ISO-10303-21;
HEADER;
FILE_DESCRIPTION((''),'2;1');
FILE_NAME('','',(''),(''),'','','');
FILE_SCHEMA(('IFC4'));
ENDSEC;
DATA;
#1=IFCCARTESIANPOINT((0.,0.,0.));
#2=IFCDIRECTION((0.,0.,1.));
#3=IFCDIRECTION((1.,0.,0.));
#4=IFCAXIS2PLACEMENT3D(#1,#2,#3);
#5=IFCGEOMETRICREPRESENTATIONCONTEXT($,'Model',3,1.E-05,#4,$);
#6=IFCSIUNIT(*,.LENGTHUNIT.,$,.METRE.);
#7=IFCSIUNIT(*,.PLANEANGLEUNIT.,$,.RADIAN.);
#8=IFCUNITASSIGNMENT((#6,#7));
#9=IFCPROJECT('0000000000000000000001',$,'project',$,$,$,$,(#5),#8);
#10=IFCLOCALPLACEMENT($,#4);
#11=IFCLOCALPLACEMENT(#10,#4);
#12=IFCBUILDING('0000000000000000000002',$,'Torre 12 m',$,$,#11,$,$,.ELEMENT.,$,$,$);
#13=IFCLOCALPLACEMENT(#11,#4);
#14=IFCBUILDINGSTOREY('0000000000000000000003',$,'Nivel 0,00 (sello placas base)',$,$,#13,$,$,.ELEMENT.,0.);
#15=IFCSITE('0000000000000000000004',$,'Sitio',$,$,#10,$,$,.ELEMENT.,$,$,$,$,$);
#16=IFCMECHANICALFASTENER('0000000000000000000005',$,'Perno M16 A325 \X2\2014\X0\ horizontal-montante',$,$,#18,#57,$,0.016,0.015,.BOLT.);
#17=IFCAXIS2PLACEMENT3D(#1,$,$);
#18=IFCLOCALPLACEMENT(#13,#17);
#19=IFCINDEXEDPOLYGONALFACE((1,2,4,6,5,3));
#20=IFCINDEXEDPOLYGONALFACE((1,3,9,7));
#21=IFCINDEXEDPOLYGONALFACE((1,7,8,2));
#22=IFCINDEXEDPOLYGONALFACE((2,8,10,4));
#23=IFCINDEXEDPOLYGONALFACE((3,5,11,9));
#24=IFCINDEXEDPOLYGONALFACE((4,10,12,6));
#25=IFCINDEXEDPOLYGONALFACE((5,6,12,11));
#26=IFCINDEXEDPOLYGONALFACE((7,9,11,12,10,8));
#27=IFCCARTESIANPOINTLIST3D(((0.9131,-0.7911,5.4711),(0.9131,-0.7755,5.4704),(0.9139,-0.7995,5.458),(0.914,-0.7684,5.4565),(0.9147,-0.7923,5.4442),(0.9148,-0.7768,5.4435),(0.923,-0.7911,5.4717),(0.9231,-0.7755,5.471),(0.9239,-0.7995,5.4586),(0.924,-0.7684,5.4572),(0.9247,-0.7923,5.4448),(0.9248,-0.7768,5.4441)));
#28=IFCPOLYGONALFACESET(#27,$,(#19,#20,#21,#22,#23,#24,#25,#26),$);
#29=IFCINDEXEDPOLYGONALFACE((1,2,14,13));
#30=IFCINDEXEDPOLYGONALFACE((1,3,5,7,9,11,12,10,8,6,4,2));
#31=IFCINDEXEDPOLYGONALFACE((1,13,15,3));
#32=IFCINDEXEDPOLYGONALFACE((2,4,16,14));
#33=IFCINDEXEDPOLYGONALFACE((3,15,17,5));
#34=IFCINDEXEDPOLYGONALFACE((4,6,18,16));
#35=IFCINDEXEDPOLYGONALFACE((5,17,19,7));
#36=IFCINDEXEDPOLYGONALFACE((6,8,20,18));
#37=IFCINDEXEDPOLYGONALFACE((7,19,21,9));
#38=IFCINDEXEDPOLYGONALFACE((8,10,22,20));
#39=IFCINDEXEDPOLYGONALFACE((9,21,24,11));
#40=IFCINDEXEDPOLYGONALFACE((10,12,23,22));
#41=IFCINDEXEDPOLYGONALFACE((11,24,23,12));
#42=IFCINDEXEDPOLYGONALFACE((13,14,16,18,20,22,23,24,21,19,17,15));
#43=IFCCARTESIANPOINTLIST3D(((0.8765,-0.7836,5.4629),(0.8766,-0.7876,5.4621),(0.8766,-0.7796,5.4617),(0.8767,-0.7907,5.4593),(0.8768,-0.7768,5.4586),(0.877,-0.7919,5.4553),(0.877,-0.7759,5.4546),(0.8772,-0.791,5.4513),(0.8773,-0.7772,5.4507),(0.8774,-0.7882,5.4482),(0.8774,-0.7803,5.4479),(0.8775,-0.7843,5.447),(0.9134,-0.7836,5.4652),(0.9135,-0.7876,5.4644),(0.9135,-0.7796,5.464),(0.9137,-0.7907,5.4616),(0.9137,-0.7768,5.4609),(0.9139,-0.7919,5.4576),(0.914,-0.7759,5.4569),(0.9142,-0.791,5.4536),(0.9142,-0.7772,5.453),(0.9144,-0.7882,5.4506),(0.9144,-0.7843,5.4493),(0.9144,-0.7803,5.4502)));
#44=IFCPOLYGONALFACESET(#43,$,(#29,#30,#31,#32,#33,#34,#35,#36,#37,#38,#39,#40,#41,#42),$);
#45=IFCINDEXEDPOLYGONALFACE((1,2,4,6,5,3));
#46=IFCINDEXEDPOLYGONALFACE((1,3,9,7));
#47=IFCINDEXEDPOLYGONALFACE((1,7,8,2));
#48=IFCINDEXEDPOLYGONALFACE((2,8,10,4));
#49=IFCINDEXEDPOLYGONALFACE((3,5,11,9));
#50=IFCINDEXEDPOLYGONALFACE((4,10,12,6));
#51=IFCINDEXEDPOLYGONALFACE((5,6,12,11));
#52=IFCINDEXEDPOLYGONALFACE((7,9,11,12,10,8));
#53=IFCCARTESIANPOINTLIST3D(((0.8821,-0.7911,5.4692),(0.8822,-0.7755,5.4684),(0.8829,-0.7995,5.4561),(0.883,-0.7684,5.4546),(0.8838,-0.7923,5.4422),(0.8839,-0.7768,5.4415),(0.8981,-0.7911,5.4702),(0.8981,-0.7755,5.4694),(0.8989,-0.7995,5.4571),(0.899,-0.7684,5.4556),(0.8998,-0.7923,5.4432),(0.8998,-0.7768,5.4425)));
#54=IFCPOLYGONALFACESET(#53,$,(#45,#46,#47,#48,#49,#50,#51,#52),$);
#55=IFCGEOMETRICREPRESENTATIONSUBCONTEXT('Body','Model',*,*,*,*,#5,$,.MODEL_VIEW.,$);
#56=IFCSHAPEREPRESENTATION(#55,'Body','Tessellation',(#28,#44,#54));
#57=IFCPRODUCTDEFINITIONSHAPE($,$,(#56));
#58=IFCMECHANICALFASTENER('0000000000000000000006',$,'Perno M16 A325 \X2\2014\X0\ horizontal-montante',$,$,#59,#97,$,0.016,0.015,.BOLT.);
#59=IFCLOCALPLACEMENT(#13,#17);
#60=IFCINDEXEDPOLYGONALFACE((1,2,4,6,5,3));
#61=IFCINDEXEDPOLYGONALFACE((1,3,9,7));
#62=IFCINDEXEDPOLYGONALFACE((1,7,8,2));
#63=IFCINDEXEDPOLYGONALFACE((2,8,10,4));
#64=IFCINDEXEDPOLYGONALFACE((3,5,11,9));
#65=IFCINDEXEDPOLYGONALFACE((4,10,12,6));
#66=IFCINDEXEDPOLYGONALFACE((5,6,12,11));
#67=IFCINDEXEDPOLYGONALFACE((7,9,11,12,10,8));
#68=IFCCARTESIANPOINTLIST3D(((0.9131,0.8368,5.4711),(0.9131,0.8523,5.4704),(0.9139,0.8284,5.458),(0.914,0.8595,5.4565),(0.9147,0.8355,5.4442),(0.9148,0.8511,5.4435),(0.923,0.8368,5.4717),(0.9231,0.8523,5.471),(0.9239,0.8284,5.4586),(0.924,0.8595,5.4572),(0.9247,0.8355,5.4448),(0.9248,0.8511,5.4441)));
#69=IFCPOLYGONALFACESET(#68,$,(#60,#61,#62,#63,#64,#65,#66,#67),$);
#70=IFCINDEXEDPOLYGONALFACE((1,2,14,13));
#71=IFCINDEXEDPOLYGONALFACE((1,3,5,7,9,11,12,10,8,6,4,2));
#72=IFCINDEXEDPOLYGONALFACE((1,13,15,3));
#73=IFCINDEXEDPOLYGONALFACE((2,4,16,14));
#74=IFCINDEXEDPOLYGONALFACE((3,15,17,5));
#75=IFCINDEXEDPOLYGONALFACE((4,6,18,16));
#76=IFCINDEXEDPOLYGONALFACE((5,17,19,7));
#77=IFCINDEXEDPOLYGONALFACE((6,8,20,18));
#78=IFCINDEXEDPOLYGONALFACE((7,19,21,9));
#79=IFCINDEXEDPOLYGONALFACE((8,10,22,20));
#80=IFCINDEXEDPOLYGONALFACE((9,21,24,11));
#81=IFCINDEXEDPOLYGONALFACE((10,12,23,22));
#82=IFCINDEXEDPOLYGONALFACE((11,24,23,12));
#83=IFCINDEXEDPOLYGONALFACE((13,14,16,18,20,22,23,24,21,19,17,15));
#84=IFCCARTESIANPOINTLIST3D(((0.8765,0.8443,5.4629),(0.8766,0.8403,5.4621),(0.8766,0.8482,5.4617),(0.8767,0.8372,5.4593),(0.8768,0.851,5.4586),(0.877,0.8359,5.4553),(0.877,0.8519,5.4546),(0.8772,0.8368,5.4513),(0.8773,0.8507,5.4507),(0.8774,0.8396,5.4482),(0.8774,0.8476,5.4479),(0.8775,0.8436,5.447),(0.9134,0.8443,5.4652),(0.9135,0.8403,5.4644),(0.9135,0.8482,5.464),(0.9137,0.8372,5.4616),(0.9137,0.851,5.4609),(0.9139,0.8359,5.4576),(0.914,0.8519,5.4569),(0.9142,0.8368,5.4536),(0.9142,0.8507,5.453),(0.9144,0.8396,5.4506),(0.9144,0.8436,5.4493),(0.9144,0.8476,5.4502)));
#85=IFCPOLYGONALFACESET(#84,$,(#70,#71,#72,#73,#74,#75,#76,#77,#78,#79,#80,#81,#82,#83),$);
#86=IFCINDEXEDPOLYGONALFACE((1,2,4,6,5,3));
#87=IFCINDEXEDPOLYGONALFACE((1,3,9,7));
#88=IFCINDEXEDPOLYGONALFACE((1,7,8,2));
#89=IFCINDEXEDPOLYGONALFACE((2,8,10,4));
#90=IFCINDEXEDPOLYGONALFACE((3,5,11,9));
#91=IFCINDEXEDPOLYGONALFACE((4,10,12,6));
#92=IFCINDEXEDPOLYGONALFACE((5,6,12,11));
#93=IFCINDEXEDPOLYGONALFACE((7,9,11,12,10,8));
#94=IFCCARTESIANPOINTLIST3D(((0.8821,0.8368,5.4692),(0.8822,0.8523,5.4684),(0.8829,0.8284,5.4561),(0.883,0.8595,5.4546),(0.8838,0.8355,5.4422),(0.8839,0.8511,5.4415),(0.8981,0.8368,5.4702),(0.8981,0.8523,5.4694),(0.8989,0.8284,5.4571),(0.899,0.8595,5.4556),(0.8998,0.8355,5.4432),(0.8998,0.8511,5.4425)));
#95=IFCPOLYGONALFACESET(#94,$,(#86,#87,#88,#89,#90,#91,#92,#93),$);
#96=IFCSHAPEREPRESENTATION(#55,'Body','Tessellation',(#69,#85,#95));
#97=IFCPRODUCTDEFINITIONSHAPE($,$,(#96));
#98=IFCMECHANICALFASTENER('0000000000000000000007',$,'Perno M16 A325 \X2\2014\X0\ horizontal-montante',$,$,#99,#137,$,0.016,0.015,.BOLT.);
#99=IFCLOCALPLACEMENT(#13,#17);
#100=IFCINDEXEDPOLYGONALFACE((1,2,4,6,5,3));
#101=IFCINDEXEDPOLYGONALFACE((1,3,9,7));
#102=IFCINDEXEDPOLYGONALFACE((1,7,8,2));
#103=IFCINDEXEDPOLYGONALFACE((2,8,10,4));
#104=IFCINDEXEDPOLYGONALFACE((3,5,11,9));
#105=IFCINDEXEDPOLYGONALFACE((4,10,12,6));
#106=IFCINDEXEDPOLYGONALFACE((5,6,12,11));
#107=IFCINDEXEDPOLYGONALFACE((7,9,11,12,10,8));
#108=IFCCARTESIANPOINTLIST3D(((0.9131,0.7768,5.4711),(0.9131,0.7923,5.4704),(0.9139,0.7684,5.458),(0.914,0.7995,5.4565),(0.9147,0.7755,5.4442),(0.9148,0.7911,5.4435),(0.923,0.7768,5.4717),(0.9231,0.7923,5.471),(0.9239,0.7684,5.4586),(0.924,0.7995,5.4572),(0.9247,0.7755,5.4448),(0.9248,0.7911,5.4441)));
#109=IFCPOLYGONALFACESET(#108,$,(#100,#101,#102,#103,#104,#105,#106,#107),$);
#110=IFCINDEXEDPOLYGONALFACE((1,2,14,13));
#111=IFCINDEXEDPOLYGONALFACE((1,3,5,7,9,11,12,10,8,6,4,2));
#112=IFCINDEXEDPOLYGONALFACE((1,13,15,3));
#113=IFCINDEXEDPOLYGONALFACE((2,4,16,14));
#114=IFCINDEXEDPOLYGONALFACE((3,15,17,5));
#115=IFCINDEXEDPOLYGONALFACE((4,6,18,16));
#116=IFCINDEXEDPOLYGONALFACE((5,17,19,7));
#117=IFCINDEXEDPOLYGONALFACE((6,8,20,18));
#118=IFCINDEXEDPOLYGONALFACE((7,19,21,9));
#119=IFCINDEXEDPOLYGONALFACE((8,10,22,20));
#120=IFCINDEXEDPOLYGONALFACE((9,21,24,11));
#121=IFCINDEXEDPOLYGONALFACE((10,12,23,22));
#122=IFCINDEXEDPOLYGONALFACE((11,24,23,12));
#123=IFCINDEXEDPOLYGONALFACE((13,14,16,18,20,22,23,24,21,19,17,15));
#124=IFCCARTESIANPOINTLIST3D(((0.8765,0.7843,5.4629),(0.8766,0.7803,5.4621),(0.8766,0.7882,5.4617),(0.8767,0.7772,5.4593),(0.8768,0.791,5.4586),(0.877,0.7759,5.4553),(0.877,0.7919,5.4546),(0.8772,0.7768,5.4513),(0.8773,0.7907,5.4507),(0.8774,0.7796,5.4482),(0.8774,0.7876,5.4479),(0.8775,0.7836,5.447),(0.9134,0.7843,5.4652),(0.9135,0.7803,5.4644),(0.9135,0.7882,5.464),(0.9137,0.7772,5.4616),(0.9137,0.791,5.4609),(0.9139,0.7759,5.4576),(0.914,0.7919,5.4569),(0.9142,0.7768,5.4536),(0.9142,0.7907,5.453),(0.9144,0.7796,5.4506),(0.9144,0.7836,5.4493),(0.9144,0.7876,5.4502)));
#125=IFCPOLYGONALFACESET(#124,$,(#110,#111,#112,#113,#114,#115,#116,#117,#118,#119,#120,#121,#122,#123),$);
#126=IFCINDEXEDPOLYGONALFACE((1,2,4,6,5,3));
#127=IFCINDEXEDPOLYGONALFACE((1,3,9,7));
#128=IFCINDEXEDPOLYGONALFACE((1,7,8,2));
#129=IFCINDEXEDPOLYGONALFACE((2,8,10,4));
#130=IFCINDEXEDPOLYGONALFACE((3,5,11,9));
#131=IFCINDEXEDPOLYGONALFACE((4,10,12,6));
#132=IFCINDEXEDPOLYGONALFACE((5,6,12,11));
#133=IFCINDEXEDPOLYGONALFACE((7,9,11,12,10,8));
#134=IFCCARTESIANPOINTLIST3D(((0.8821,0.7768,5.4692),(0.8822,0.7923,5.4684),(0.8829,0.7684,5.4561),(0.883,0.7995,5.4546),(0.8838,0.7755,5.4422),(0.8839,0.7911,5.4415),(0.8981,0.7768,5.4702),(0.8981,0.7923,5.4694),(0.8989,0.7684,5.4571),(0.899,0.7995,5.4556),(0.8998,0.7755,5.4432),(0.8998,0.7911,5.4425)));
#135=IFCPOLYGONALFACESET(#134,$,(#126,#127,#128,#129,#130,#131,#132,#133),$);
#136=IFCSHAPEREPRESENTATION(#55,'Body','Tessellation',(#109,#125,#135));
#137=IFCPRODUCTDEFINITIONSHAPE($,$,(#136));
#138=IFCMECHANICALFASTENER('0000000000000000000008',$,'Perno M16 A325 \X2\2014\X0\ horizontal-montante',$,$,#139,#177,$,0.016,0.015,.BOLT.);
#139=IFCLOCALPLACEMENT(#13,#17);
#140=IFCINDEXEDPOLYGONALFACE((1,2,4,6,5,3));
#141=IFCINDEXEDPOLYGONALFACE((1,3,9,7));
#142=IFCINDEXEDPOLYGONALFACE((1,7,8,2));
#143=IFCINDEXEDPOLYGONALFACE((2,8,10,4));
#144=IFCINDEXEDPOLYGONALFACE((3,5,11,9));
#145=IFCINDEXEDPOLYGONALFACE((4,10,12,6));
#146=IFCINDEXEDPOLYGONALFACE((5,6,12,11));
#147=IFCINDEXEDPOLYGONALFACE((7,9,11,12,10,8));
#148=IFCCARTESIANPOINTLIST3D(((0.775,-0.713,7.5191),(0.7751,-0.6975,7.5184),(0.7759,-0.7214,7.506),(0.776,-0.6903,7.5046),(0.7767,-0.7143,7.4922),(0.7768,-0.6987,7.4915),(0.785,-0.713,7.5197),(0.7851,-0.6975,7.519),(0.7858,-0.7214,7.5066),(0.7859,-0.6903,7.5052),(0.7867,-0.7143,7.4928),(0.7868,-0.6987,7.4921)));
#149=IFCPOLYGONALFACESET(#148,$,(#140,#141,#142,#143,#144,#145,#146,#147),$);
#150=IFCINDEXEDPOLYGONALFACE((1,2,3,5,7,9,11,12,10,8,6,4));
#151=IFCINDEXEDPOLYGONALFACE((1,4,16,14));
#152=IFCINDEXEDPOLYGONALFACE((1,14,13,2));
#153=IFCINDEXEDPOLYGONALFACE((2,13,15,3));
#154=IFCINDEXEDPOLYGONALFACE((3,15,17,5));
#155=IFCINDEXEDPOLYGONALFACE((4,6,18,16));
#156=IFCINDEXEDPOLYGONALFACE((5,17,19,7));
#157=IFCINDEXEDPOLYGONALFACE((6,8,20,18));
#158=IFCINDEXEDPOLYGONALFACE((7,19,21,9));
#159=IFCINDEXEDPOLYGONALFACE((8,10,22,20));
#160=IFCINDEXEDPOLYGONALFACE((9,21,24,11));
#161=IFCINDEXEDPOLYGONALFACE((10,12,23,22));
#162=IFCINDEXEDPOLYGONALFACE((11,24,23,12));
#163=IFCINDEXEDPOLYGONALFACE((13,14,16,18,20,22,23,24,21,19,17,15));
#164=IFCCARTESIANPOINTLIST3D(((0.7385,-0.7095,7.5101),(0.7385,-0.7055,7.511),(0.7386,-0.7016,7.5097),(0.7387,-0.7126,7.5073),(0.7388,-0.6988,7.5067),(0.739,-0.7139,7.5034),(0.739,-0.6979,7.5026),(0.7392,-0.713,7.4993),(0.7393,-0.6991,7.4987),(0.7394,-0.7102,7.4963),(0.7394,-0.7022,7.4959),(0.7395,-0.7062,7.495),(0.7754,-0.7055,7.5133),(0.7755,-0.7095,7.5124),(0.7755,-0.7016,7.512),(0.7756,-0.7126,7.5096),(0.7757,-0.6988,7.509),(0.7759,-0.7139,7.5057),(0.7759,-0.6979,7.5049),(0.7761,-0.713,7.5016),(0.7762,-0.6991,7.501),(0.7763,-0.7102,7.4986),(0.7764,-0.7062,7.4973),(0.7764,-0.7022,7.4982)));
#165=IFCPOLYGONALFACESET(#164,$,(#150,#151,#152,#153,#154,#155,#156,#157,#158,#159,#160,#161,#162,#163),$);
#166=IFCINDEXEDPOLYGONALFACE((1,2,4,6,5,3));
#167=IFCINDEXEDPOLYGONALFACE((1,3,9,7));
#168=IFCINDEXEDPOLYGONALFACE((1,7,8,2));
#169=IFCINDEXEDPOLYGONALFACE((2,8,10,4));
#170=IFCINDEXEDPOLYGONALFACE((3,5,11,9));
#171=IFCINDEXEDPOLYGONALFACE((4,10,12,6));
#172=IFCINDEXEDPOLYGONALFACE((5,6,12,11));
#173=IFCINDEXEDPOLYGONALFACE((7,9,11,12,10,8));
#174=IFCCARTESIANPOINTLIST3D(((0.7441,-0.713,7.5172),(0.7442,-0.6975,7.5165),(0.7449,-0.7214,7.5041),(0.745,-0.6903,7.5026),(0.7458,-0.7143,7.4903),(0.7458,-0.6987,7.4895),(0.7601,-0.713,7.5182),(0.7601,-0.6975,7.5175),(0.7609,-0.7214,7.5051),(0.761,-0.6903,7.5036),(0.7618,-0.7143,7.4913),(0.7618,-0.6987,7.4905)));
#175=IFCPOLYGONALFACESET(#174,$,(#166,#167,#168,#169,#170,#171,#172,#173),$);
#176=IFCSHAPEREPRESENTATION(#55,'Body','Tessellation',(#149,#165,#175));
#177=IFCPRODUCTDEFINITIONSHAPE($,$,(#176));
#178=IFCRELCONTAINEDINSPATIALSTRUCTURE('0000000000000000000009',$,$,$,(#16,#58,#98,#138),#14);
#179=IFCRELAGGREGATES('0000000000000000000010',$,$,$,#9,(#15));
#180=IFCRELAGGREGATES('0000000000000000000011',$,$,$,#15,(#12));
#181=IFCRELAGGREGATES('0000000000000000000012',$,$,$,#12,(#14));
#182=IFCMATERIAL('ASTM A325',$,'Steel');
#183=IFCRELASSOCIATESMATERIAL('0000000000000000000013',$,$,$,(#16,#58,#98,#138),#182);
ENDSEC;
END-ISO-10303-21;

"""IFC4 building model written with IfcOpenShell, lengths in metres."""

from ifc_helpers import new_model, si_unit, frame, origin_with_axes, place, context, subcontext, project, spatial, polyline, outline, extrude, material, element, save


model = new_model("IFC4")

# Units and contexts
model_context = context("Model", 3, precision=1e-05, world=origin_with_axes())
body_context = subcontext(model_context, "Body", "Model", "MODEL_VIEW")
ifc_project = project(units=[si_unit("LENGTHUNIT", "METRE"), si_unit("PLANEANGLEUNIT", "RADIAN")], contexts=[model_context])

# Site, building, storey
site_placement = place(None, origin_with_axes())
site = spatial("IfcSite", under=ifc_project, at=site_placement, Name="Sitio", CompositionType="ELEMENT")
building_placement = place(site_placement, origin_with_axes())
building = spatial("IfcBuilding", under=site, at=building_placement, Name="Torre 12 m", CompositionType="ELEMENT")
storey_placement = place(building_placement, origin_with_axes())
storey = spatial("IfcBuildingStorey", under=building, at=storey_placement, Name="Nivel 0,00 (sello placas base)", CompositionType="ELEMENT", Elevation=0.0)

# Shared definitions
placement = place(storey_placement, origin_with_axes())

# Mechanical fasteners
ifc_material_1 = material(Name="ASTM A325", Category="Steel")
element("IfcMechanicalFastener", 1, at=placement, inside=storey, material=ifc_material_1, Name="Perno M16 A325 — horizontal-montante", NominalDiameter=0.016, NominalLength=0.015, PredefinedType="BOLT", context=body_context, shape_type="SweptSolid", body=[
    extrude(outline(polyline([(0.0135, 0.0078), (0.0, 0.0156), (-0.0135, 0.0078), (-0.0135, -0.0078), (0.0, -0.0156), (0.0135, -0.0078), (0.0135, 0.0078)])), frame((0.9239, -0.7839, 5.4579), z_axis=(-0.998053, 0.0, -0.062378), x_axis=(0.033672, 0.841794, -0.538748)), (0.0, 0.0, 1.0), 0.01),
    extrude(outline(polyline([(0.008, 0.0), (0.0069, 0.004), (0.004, 0.0069), (0.0, 0.008), (-0.004, 0.0069), (-0.0069, 0.004), (-0.008, 0.0), (-0.0069, -0.004), (-0.004, -0.0069), (0.0, -0.008), (0.004, -0.0069), (0.0069, -0.004), (0.008, 0.0)])), frame((0.9139, -0.7839, 5.4573), z_axis=(-0.998053, 0.0, -0.062378), x_axis=(0.033672, 0.841794, -0.538748)), (0.0, 0.0, 1.0), 0.037),
    extrude(outline(polyline([(0.0135, 0.0078), (0.0, 0.0156), (-0.0135, 0.0078), (-0.0135, -0.0078), (0.0, -0.0156), (0.0135, -0.0078), (0.0135, 0.0078)])), frame((0.899, -0.7839, 5.4563), z_axis=(-0.998053, 0.0, -0.062378), x_axis=(0.033672, 0.841794, -0.538748)), (0.0, 0.0, 1.0), 0.016),
])
element("IfcMechanicalFastener", 2, at=placement, inside=storey, material=ifc_material_1, Name="Perno M16 A325 — horizontal-montante", NominalDiameter=0.016, NominalLength=0.015, PredefinedType="BOLT", context=body_context, shape_type="SweptSolid", body=[
    extrude(outline(polyline([(0.0135, 0.0078), (0.0, 0.0156), (-0.0135, 0.0078), (-0.0135, -0.0078), (0.0, -0.0156), (0.0135, -0.0078), (0.0135, 0.0078)])), frame((0.9239, 0.8439, 5.4579), z_axis=(-0.998053, 0.0, -0.062378), x_axis=(0.033672, 0.841794, -0.538748)), (0.0, 0.0, 1.0), 0.01),
    extrude(outline(polyline([(0.008, 0.0), (0.0069, 0.004), (0.004, 0.0069), (0.0, 0.008), (-0.004, 0.0069), (-0.0069, 0.004), (-0.008, 0.0), (-0.0069, -0.004), (-0.004, -0.0069), (0.0, -0.008), (0.004, -0.0069), (0.0069, -0.004), (0.008, 0.0)])), frame((0.9139, 0.8439, 5.4573), z_axis=(-0.998053, 0.0, -0.062378), x_axis=(0.033672, 0.841794, -0.538748)), (0.0, 0.0, 1.0), 0.037),
    extrude(outline(polyline([(0.0135, 0.0078), (0.0, 0.0156), (-0.0135, 0.0078), (-0.0135, -0.0078), (0.0, -0.0156), (0.0135, -0.0078), (0.0135, 0.0078)])), frame((0.899, 0.8439, 5.4563), z_axis=(-0.998053, 0.0, -0.062378), x_axis=(0.033672, 0.841794, -0.538748)), (0.0, 0.0, 1.0), 0.016),
])
element("IfcMechanicalFastener", 3, at=placement, inside=storey, material=ifc_material_1, Name="Perno M16 A325 — horizontal-montante", NominalDiameter=0.016, NominalLength=0.015, PredefinedType="BOLT", context=body_context, shape_type="SweptSolid", body=[
    extrude(outline(polyline([(0.0135, 0.0078), (0.0, 0.0156), (-0.0135, 0.0078), (-0.0135, -0.0078), (0.0, -0.0156), (0.0135, -0.0078), (0.0135, 0.0078)])), frame((0.9239, 0.7839, 5.4579), z_axis=(-0.998053, 0.0, -0.062378), x_axis=(0.033672, 0.841794, -0.538748)), (0.0, 0.0, 1.0), 0.01),
    extrude(outline(polyline([(0.008, 0.0), (0.0069, 0.004), (0.004, 0.0069), (0.0, 0.008), (-0.004, 0.0069), (-0.0069, 0.004), (-0.008, 0.0), (-0.0069, -0.004), (-0.004, -0.0069), (0.0, -0.008), (0.004, -0.0069), (0.0069, -0.004), (0.008, 0.0)])), frame((0.9139, 0.7839, 5.4573), z_axis=(-0.998053, 0.0, -0.062378), x_axis=(0.033672, 0.841794, -0.538748)), (0.0, 0.0, 1.0), 0.037),
    extrude(outline(polyline([(0.0135, 0.0078), (0.0, 0.0156), (-0.0135, 0.0078), (-0.0135, -0.0078), (0.0, -0.0156), (0.0135, -0.0078), (0.0135, 0.0078)])), frame((0.899, 0.7839, 5.4563), z_axis=(-0.998053, 0.0, -0.062378), x_axis=(0.033672, 0.841794, -0.538748)), (0.0, 0.0, 1.0), 0.016),
])
element("IfcMechanicalFastener", 4, at=placement, inside=storey, material=ifc_material_1, Name="Perno M16 A325 — horizontal-montante", NominalDiameter=0.016, NominalLength=0.015, PredefinedType="BOLT", context=body_context, shape_type="SweptSolid", body=[
    extrude(outline(polyline([(0.0135, 0.0078), (0.0, 0.0156), (-0.0135, 0.0078), (-0.0135, -0.0078), (0.0, -0.0156), (0.0135, -0.0078), (0.0135, 0.0078)])), frame((0.7859, -0.7059, 7.5059), z_axis=(-0.998053, 0.0, -0.062378), x_axis=(0.033672, 0.841794, -0.538748)), (0.0, 0.0, 1.0), 0.01),
    extrude(outline(polyline([(0.008, 0.0), (0.0069, 0.004), (0.004, 0.0069), (0.0, 0.008), (-0.004, 0.0069), (-0.0069, 0.004), (-0.008, 0.0), (-0.0069, -0.004), (-0.004, -0.0069), (0.0, -0.008), (0.004, -0.0069), (0.0069, -0.004), (0.008, 0.0)])), frame((0.7759, -0.7059, 7.5053), z_axis=(-0.998053, 0.0, -0.062378), x_axis=(0.033672, 0.841794, -0.538748)), (0.0, 0.0, 1.0), 0.037),
    extrude(outline(polyline([(0.0135, 0.0078), (0.0, 0.0156), (-0.0135, 0.0078), (-0.0135, -0.0078), (0.0, -0.0156), (0.0135, -0.0078), (0.0135, 0.0078)])), frame((0.7609, -0.7059, 7.5044), z_axis=(-0.998053, 0.0, -0.062378), x_axis=(0.033672, 0.841794, -0.538748)), (0.0, 0.0, 1.0), 0.016),
])

save(model, "model.ifc")
